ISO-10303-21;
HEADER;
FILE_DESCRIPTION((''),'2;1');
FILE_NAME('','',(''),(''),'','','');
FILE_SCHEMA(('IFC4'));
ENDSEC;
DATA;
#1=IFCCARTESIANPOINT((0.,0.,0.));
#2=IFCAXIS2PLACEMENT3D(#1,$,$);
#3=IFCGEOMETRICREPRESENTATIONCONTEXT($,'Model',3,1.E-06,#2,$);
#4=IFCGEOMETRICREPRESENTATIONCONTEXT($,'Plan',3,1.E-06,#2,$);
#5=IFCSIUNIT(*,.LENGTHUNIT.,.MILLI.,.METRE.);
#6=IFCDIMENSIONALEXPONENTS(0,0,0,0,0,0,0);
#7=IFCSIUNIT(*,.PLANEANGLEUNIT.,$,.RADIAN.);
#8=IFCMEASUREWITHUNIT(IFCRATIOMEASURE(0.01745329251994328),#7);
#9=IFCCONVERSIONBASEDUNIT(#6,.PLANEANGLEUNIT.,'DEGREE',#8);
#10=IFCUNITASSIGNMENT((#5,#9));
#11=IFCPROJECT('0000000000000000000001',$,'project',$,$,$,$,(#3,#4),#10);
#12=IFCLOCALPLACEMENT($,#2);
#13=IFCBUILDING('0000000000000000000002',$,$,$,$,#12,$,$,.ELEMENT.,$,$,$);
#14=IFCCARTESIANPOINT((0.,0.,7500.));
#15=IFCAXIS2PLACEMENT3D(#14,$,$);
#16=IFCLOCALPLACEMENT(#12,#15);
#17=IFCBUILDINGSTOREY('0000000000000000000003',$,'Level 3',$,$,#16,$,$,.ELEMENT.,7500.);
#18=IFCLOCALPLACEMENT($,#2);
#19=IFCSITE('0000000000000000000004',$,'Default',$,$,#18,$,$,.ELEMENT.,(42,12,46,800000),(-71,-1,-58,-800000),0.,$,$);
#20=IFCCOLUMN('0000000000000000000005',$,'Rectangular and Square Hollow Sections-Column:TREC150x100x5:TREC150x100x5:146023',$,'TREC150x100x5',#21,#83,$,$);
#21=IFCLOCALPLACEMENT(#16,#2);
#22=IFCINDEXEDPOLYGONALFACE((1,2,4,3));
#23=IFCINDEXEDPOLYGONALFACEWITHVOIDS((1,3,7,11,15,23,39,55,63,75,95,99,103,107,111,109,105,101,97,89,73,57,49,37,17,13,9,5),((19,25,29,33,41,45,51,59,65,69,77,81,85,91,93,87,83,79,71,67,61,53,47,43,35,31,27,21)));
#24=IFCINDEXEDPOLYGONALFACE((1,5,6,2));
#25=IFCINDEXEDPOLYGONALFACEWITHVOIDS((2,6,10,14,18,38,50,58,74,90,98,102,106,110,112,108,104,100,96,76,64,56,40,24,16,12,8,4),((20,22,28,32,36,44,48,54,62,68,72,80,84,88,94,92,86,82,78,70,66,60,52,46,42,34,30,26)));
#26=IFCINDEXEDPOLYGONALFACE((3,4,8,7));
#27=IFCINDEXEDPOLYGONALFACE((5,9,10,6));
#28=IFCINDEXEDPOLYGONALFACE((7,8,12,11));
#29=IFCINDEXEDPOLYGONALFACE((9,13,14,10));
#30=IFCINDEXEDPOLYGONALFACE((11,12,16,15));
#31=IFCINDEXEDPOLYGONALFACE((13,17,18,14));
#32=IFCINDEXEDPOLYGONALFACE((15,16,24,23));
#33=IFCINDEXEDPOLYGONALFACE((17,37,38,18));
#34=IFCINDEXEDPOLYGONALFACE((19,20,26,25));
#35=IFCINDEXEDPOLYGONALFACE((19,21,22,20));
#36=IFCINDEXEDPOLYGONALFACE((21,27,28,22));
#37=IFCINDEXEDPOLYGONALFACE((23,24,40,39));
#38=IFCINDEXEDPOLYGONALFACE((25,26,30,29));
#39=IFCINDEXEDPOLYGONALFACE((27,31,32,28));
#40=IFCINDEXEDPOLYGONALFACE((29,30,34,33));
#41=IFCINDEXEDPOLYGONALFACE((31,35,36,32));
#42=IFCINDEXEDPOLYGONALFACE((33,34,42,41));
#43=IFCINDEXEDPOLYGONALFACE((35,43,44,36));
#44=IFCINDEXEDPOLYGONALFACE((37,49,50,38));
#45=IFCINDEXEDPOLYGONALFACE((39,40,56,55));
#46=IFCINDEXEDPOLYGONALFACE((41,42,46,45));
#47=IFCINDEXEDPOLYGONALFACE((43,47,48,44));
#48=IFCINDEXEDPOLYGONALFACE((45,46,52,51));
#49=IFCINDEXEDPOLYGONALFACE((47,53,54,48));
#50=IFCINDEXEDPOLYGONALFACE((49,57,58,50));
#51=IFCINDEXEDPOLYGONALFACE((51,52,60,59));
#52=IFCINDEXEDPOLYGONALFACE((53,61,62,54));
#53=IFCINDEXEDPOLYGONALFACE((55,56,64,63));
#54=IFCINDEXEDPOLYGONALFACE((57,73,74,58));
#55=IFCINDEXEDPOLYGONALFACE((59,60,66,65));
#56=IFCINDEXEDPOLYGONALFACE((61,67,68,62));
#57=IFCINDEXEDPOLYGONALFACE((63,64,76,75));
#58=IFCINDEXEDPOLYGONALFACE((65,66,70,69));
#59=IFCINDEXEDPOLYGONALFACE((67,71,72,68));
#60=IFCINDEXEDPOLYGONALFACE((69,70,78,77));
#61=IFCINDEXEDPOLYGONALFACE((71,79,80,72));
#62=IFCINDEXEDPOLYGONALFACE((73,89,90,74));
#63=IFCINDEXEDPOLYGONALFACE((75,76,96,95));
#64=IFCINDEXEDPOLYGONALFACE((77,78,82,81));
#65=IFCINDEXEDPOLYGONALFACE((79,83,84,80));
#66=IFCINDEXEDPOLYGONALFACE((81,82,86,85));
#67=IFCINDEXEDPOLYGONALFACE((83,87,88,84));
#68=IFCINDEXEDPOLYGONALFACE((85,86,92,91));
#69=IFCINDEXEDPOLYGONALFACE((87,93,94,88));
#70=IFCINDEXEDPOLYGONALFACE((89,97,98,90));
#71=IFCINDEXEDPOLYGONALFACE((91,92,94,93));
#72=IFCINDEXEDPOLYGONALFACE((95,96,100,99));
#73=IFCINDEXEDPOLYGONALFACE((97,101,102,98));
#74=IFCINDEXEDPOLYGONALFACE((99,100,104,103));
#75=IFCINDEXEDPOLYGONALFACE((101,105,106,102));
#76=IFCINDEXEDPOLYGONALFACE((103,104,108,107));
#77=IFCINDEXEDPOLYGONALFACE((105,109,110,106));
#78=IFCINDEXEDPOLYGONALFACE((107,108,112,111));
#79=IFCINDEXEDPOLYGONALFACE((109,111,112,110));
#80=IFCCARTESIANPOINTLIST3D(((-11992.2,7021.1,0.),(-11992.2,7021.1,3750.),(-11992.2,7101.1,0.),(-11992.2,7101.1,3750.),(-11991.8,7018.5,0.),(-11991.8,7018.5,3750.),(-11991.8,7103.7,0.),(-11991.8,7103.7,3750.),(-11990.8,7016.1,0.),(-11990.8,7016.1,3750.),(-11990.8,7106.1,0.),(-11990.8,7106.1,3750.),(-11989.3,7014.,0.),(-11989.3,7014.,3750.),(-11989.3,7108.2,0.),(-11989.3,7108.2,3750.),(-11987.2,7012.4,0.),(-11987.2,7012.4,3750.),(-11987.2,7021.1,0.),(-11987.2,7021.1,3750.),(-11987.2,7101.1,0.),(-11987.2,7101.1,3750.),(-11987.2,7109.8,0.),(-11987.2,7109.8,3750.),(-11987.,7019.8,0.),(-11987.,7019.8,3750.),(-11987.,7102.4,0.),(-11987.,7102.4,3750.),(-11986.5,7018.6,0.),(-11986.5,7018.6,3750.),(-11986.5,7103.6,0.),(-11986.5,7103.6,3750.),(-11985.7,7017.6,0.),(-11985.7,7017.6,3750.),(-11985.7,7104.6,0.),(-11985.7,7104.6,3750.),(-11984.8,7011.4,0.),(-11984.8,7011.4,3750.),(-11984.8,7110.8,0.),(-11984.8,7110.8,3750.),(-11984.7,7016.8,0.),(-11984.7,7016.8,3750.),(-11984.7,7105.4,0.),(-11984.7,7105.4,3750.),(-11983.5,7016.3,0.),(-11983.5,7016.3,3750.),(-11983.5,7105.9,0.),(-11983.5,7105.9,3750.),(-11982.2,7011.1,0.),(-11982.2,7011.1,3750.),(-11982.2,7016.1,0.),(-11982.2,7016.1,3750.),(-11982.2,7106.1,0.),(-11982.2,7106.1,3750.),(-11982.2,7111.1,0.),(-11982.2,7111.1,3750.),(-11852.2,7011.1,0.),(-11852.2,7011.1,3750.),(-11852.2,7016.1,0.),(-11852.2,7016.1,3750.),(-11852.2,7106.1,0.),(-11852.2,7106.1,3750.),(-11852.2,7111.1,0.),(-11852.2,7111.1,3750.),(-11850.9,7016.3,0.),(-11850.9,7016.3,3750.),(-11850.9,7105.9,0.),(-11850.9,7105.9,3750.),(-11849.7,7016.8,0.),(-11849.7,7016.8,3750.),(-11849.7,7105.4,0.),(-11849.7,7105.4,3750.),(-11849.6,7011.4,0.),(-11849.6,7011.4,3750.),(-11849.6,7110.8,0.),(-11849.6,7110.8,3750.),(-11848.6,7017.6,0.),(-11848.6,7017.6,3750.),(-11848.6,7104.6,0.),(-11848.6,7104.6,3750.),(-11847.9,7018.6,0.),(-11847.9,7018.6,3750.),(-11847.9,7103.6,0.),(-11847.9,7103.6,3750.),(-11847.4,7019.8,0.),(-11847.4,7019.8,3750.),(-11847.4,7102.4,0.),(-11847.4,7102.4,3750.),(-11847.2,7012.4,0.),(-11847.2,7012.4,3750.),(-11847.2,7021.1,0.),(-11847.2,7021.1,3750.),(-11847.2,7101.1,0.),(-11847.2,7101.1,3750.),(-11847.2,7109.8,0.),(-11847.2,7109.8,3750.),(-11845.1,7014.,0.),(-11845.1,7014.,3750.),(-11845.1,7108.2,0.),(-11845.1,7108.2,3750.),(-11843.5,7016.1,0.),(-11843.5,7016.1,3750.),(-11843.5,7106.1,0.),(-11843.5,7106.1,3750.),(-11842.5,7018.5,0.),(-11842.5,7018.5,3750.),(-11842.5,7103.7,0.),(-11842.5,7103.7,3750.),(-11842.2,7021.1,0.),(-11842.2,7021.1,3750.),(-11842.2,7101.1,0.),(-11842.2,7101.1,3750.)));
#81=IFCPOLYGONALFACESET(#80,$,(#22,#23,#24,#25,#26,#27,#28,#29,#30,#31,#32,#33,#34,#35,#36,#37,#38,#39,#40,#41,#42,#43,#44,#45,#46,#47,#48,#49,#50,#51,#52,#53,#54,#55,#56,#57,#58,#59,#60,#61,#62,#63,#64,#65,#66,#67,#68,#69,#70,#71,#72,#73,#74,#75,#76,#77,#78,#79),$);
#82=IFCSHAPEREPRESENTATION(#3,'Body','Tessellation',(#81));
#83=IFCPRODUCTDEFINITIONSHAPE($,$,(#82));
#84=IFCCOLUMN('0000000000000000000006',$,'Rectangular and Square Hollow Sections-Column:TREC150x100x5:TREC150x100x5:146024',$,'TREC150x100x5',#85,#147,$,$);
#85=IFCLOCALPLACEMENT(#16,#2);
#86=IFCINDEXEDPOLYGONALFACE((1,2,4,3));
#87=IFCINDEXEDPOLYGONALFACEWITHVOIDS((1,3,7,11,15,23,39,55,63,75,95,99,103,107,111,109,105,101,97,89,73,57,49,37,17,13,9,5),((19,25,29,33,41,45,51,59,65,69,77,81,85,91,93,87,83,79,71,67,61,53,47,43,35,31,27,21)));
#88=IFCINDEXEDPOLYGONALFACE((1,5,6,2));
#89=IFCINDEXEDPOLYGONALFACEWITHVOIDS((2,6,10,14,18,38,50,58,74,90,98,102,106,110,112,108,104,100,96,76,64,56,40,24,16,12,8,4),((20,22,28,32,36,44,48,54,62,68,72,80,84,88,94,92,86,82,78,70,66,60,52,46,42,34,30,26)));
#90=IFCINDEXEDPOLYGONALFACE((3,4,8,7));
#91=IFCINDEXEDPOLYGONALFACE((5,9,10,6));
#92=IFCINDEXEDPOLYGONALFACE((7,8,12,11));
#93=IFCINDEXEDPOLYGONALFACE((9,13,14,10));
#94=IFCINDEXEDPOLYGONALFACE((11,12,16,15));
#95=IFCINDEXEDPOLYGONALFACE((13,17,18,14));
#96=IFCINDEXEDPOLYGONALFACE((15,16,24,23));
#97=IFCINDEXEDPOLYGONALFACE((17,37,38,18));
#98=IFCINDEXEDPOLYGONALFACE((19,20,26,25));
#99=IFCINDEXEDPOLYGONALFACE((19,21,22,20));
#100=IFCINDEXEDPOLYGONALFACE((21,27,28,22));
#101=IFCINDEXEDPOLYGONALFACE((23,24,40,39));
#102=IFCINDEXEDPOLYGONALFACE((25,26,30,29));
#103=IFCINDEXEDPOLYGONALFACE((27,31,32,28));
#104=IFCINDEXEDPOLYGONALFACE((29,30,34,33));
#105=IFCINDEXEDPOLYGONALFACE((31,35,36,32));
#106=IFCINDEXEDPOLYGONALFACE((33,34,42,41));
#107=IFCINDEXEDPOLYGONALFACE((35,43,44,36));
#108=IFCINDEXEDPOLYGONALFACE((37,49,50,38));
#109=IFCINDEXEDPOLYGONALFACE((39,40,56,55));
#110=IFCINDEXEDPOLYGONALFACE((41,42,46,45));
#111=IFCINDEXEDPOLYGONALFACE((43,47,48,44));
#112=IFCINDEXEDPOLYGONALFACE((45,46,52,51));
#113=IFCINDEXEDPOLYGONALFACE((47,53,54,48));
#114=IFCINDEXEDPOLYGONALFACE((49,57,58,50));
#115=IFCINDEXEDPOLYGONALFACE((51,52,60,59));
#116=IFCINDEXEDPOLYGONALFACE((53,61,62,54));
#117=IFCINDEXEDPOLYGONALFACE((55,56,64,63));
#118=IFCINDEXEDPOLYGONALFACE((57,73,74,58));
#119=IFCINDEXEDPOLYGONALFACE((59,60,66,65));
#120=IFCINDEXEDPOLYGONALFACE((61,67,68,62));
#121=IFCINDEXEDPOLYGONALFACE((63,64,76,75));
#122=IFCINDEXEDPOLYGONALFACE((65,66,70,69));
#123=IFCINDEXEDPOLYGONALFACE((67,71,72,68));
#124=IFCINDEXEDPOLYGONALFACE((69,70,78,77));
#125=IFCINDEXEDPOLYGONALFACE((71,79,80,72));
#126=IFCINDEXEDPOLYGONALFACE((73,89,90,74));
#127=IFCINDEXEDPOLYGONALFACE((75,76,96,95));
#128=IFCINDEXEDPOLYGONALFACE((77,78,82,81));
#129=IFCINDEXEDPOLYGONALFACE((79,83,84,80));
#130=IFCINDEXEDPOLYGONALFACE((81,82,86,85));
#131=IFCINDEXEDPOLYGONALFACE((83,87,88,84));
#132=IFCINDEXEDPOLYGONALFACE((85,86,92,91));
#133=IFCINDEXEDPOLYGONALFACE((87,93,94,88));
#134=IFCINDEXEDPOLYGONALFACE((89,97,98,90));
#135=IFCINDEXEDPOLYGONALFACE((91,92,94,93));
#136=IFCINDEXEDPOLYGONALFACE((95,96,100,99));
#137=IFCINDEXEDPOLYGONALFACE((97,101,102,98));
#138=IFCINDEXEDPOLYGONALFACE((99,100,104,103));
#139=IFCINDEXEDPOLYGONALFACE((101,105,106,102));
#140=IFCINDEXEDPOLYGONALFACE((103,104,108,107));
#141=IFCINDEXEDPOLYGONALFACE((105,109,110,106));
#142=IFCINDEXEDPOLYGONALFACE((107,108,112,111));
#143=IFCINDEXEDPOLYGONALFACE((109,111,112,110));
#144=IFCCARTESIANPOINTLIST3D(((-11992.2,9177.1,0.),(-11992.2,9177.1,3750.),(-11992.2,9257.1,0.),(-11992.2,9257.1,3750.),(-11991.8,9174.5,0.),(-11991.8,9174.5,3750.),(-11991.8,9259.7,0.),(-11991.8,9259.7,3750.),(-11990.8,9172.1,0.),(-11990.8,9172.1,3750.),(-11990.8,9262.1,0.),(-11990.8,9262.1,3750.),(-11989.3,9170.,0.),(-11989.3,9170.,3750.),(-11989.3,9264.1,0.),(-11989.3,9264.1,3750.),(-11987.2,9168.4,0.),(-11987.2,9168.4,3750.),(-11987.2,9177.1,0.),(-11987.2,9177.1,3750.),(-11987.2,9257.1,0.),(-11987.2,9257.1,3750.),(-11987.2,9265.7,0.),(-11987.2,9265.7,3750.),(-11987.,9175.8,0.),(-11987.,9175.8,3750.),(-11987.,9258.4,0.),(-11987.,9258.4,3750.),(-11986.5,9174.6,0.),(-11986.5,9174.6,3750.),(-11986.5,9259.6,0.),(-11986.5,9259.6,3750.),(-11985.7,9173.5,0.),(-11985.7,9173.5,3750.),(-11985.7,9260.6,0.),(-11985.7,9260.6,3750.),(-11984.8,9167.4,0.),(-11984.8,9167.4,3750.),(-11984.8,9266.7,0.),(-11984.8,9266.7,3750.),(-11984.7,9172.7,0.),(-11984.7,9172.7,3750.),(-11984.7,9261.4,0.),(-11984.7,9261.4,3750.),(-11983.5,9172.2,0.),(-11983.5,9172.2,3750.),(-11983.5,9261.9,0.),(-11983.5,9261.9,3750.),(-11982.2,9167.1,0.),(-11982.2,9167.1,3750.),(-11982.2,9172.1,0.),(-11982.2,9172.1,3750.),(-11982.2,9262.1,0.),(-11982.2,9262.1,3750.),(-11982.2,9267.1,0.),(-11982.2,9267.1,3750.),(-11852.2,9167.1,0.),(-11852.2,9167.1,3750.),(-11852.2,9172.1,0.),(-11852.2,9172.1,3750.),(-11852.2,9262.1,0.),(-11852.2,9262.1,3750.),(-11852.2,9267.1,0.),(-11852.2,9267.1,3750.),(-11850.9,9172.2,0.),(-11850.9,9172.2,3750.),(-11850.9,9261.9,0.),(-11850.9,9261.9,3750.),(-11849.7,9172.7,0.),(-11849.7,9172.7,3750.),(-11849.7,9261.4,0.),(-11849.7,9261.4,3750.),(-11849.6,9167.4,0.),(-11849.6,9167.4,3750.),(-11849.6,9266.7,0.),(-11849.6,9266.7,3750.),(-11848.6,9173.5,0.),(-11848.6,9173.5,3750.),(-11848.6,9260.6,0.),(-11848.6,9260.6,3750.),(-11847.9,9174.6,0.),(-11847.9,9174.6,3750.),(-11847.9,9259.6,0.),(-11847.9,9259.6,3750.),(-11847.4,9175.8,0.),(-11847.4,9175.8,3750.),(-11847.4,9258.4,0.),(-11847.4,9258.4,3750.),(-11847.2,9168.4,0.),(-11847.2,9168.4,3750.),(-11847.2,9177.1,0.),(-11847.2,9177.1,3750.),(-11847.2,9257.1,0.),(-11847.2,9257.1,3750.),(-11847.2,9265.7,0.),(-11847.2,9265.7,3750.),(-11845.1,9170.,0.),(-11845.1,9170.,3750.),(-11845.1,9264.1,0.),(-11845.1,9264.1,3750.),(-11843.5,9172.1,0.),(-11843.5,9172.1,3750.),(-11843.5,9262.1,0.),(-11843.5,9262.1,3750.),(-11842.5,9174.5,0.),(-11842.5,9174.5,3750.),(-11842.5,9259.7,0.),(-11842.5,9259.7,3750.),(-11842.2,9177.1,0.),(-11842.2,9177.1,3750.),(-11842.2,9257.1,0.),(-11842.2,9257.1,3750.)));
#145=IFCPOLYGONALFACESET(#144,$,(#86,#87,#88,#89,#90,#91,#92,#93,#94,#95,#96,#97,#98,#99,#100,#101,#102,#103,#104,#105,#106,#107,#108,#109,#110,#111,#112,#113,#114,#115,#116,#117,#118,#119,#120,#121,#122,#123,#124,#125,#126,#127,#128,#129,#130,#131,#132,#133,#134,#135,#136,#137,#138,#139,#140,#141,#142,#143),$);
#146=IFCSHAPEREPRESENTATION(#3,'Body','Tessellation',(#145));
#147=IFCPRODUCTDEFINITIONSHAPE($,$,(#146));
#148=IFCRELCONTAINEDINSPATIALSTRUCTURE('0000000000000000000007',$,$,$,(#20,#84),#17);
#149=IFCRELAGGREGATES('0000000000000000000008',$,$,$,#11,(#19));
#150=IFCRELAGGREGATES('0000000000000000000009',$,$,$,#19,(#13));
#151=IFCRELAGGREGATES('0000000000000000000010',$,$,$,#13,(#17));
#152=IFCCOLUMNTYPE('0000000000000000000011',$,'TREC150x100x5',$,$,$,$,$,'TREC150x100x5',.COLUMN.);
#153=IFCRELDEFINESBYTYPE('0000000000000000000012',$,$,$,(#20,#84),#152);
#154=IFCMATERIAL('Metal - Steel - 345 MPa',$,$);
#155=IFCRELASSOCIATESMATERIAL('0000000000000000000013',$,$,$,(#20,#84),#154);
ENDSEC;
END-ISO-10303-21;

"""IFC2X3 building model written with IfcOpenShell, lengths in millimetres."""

from ifc_helpers import new_model, entity, si_unit, converted_unit, frame, frame_2d, origin, place, context, project, spatial, polyline, circle_curve, parameter, trimmed, segment, composite_curve, outline, extrude, source, transform, mapped, material, type_object, type_shapes, element, save


model = new_model("IFC2X3")

# Units and contexts
model_context = context("Model", 3, precision=1e-06, world=origin())
plan_context = context("Plan", 3, precision=1e-06, world=origin())
ifc_project = project(units=[si_unit("LENGTHUNIT", "METRE", prefix="MILLI"), converted_unit("PLANEANGLEUNIT", "DEGREE", entity("IfcRatioMeasure", 0.01745329251994328), si_unit("PLANEANGLEUNIT", "RADIAN"), dimensions=[0, 0, 0, 0, 0, 0, 0])], contexts=[model_context, plan_context])

# Site, building, storey
site_placement = place(None, origin())
site = spatial("IfcSite", under=ifc_project, at=site_placement, Name="Default", CompositionType="ELEMENT", RefLatitude=(42, 12, 46, 800000), RefLongitude=(-71, -1, -58, -800000), RefElevation=0.0)
building_placement = place(None, origin())
building = spatial("IfcBuilding", under=site, at=building_placement, CompositionType="ELEMENT")
storey_placement = place(building_placement, frame((0.0, 0.0, 7500.0)))
storey = spatial("IfcBuildingStorey", under=building, at=storey_placement, Name="Level 3", CompositionType="ELEMENT", Elevation=7500.0)

# Columns
ifc_material_1 = material(Name="Metal - Steel - 345 MPa")
column_type = type_object("IfcColumnType", Name="TREC150x100x5", ElementType="TREC150x100x5", PredefinedType="COLUMN")
shared_shape = source(origin(), model_context, "Body", "SweptSolid", [
    extrude(outline(composite_curve([segment(polyline([(-40.0, -75.0), (40.0, -75.0)]), True, "CONTINUOUS"), segment(trimmed(circle_curve(frame_2d((40.0, -65.0), x_axis=(-1.0, 0.0)), 10.0), [parameter(90.0)], [parameter(180.0)], True, "PARAMETER"), True, "CONTINUOUS"), segment(polyline([(50.0, -65.0), (50.0, 65.0)]), True, "CONTINUOUS"), segment(trimmed(circle_curve(frame_2d((40.0, 65.0), x_axis=(-1.0, 0.0)), 10.0), [parameter(180.0)], [parameter(270.0)], True, "PARAMETER"), True, "CONTINUOUS"), segment(polyline([(40.0, 75.0), (-40.0, 75.0)]), True, "CONTINUOUS"), segment(trimmed(circle_curve(frame_2d((-40.0, 65.0), x_axis=(-1.0, 0.0)), 10.0), [parameter(270.0)], [parameter(360.0)], True, "PARAMETER"), True, "CONTINUOUS"), segment(polyline([(-50.0, 65.0), (-50.0, -65.0)]), True, "CONTINUOUS"), segment(trimmed(circle_curve(frame_2d((-40.0, -65.0), x_axis=(-1.0, 0.0)), 10.0), [parameter(360.0)], [parameter(90.0)], True, "PARAMETER"), True, "CONTINUOUS")], self_intersect=False), holes=[composite_curve([segment(trimmed(circle_curve(frame_2d((-40.0, -65.0), x_axis=(-1.0, 0.0)), 5.0), [parameter(0.0)], [parameter(90.0)], True, "PARAMETER"), False, "CONTINUOUS"), segment(polyline([(-45.0, -65.0), (-45.0, 65.0)]), True, "CONTINUOUS"), segment(trimmed(circle_curve(frame_2d((-40.0, 65.0), x_axis=(-1.0, 0.0)), 5.0), [parameter(270.0)], [parameter(360.0)], True, "PARAMETER"), False, "CONTINUOUS"), segment(polyline([(-40.0, 70.0), (40.0, 70.0)]), True, "CONTINUOUS"), segment(trimmed(circle_curve(frame_2d((40.0, 65.0), x_axis=(-1.0, 0.0)), 5.0), [parameter(180.0)], [parameter(270.0)], True, "PARAMETER"), False, "CONTINUOUS"), segment(polyline([(45.0, 65.0), (45.0, -65.0)]), True, "CONTINUOUS"), segment(trimmed(circle_curve(frame_2d((40.0, -65.0), x_axis=(-1.0, 0.0)), 5.0), [parameter(90.0)], [parameter(180.0)], True, "PARAMETER"), False, "CONTINUOUS"), segment(polyline([(40.0, -70.0), (-40.0, -70.0)]), True, "CONTINUOUS")], self_intersect=False)]), frame((0.0, 0.0, 7500.0), z_axis=(0.0, 0.0, 1.0), x_axis=(-1.0, 0.0, 0.0)), (0.0, 0.0, 1.0), 3750.0),
])
type_shapes(column_type, [shared_shape])
for number, where, z_axis, x_axis, name in (
    (1, (-11917.2, 7061.1, -7500.0), (0.0, 0.0, 1.0), (0.0, 1.0, 0.0), "Rectangular and Square Hollow Sections-Column:TREC150x100x5:TREC150x100x5:146023"),
    (2, (-11917.2, 9217.1, -7500.0), (0.0, 0.0, 1.0), (0.0, 1.0, 0.0), "Rectangular and Square Hollow Sections-Column:TREC150x100x5:TREC150x100x5:146024"),
):
    element("IfcColumn", number, at=place(storey_placement, frame(where, z_axis=z_axis, x_axis=x_axis)), inside=storey, type_object=column_type, material=ifc_material_1, Name=name, ObjectType="TREC150x100x5", context=model_context, shape_type="MappedRepresentation", body=[
        mapped(shared_shape, transform((0.0, 0.0, 0.0), scale=1.0)),
    ])

save(model, "model.ifc")
